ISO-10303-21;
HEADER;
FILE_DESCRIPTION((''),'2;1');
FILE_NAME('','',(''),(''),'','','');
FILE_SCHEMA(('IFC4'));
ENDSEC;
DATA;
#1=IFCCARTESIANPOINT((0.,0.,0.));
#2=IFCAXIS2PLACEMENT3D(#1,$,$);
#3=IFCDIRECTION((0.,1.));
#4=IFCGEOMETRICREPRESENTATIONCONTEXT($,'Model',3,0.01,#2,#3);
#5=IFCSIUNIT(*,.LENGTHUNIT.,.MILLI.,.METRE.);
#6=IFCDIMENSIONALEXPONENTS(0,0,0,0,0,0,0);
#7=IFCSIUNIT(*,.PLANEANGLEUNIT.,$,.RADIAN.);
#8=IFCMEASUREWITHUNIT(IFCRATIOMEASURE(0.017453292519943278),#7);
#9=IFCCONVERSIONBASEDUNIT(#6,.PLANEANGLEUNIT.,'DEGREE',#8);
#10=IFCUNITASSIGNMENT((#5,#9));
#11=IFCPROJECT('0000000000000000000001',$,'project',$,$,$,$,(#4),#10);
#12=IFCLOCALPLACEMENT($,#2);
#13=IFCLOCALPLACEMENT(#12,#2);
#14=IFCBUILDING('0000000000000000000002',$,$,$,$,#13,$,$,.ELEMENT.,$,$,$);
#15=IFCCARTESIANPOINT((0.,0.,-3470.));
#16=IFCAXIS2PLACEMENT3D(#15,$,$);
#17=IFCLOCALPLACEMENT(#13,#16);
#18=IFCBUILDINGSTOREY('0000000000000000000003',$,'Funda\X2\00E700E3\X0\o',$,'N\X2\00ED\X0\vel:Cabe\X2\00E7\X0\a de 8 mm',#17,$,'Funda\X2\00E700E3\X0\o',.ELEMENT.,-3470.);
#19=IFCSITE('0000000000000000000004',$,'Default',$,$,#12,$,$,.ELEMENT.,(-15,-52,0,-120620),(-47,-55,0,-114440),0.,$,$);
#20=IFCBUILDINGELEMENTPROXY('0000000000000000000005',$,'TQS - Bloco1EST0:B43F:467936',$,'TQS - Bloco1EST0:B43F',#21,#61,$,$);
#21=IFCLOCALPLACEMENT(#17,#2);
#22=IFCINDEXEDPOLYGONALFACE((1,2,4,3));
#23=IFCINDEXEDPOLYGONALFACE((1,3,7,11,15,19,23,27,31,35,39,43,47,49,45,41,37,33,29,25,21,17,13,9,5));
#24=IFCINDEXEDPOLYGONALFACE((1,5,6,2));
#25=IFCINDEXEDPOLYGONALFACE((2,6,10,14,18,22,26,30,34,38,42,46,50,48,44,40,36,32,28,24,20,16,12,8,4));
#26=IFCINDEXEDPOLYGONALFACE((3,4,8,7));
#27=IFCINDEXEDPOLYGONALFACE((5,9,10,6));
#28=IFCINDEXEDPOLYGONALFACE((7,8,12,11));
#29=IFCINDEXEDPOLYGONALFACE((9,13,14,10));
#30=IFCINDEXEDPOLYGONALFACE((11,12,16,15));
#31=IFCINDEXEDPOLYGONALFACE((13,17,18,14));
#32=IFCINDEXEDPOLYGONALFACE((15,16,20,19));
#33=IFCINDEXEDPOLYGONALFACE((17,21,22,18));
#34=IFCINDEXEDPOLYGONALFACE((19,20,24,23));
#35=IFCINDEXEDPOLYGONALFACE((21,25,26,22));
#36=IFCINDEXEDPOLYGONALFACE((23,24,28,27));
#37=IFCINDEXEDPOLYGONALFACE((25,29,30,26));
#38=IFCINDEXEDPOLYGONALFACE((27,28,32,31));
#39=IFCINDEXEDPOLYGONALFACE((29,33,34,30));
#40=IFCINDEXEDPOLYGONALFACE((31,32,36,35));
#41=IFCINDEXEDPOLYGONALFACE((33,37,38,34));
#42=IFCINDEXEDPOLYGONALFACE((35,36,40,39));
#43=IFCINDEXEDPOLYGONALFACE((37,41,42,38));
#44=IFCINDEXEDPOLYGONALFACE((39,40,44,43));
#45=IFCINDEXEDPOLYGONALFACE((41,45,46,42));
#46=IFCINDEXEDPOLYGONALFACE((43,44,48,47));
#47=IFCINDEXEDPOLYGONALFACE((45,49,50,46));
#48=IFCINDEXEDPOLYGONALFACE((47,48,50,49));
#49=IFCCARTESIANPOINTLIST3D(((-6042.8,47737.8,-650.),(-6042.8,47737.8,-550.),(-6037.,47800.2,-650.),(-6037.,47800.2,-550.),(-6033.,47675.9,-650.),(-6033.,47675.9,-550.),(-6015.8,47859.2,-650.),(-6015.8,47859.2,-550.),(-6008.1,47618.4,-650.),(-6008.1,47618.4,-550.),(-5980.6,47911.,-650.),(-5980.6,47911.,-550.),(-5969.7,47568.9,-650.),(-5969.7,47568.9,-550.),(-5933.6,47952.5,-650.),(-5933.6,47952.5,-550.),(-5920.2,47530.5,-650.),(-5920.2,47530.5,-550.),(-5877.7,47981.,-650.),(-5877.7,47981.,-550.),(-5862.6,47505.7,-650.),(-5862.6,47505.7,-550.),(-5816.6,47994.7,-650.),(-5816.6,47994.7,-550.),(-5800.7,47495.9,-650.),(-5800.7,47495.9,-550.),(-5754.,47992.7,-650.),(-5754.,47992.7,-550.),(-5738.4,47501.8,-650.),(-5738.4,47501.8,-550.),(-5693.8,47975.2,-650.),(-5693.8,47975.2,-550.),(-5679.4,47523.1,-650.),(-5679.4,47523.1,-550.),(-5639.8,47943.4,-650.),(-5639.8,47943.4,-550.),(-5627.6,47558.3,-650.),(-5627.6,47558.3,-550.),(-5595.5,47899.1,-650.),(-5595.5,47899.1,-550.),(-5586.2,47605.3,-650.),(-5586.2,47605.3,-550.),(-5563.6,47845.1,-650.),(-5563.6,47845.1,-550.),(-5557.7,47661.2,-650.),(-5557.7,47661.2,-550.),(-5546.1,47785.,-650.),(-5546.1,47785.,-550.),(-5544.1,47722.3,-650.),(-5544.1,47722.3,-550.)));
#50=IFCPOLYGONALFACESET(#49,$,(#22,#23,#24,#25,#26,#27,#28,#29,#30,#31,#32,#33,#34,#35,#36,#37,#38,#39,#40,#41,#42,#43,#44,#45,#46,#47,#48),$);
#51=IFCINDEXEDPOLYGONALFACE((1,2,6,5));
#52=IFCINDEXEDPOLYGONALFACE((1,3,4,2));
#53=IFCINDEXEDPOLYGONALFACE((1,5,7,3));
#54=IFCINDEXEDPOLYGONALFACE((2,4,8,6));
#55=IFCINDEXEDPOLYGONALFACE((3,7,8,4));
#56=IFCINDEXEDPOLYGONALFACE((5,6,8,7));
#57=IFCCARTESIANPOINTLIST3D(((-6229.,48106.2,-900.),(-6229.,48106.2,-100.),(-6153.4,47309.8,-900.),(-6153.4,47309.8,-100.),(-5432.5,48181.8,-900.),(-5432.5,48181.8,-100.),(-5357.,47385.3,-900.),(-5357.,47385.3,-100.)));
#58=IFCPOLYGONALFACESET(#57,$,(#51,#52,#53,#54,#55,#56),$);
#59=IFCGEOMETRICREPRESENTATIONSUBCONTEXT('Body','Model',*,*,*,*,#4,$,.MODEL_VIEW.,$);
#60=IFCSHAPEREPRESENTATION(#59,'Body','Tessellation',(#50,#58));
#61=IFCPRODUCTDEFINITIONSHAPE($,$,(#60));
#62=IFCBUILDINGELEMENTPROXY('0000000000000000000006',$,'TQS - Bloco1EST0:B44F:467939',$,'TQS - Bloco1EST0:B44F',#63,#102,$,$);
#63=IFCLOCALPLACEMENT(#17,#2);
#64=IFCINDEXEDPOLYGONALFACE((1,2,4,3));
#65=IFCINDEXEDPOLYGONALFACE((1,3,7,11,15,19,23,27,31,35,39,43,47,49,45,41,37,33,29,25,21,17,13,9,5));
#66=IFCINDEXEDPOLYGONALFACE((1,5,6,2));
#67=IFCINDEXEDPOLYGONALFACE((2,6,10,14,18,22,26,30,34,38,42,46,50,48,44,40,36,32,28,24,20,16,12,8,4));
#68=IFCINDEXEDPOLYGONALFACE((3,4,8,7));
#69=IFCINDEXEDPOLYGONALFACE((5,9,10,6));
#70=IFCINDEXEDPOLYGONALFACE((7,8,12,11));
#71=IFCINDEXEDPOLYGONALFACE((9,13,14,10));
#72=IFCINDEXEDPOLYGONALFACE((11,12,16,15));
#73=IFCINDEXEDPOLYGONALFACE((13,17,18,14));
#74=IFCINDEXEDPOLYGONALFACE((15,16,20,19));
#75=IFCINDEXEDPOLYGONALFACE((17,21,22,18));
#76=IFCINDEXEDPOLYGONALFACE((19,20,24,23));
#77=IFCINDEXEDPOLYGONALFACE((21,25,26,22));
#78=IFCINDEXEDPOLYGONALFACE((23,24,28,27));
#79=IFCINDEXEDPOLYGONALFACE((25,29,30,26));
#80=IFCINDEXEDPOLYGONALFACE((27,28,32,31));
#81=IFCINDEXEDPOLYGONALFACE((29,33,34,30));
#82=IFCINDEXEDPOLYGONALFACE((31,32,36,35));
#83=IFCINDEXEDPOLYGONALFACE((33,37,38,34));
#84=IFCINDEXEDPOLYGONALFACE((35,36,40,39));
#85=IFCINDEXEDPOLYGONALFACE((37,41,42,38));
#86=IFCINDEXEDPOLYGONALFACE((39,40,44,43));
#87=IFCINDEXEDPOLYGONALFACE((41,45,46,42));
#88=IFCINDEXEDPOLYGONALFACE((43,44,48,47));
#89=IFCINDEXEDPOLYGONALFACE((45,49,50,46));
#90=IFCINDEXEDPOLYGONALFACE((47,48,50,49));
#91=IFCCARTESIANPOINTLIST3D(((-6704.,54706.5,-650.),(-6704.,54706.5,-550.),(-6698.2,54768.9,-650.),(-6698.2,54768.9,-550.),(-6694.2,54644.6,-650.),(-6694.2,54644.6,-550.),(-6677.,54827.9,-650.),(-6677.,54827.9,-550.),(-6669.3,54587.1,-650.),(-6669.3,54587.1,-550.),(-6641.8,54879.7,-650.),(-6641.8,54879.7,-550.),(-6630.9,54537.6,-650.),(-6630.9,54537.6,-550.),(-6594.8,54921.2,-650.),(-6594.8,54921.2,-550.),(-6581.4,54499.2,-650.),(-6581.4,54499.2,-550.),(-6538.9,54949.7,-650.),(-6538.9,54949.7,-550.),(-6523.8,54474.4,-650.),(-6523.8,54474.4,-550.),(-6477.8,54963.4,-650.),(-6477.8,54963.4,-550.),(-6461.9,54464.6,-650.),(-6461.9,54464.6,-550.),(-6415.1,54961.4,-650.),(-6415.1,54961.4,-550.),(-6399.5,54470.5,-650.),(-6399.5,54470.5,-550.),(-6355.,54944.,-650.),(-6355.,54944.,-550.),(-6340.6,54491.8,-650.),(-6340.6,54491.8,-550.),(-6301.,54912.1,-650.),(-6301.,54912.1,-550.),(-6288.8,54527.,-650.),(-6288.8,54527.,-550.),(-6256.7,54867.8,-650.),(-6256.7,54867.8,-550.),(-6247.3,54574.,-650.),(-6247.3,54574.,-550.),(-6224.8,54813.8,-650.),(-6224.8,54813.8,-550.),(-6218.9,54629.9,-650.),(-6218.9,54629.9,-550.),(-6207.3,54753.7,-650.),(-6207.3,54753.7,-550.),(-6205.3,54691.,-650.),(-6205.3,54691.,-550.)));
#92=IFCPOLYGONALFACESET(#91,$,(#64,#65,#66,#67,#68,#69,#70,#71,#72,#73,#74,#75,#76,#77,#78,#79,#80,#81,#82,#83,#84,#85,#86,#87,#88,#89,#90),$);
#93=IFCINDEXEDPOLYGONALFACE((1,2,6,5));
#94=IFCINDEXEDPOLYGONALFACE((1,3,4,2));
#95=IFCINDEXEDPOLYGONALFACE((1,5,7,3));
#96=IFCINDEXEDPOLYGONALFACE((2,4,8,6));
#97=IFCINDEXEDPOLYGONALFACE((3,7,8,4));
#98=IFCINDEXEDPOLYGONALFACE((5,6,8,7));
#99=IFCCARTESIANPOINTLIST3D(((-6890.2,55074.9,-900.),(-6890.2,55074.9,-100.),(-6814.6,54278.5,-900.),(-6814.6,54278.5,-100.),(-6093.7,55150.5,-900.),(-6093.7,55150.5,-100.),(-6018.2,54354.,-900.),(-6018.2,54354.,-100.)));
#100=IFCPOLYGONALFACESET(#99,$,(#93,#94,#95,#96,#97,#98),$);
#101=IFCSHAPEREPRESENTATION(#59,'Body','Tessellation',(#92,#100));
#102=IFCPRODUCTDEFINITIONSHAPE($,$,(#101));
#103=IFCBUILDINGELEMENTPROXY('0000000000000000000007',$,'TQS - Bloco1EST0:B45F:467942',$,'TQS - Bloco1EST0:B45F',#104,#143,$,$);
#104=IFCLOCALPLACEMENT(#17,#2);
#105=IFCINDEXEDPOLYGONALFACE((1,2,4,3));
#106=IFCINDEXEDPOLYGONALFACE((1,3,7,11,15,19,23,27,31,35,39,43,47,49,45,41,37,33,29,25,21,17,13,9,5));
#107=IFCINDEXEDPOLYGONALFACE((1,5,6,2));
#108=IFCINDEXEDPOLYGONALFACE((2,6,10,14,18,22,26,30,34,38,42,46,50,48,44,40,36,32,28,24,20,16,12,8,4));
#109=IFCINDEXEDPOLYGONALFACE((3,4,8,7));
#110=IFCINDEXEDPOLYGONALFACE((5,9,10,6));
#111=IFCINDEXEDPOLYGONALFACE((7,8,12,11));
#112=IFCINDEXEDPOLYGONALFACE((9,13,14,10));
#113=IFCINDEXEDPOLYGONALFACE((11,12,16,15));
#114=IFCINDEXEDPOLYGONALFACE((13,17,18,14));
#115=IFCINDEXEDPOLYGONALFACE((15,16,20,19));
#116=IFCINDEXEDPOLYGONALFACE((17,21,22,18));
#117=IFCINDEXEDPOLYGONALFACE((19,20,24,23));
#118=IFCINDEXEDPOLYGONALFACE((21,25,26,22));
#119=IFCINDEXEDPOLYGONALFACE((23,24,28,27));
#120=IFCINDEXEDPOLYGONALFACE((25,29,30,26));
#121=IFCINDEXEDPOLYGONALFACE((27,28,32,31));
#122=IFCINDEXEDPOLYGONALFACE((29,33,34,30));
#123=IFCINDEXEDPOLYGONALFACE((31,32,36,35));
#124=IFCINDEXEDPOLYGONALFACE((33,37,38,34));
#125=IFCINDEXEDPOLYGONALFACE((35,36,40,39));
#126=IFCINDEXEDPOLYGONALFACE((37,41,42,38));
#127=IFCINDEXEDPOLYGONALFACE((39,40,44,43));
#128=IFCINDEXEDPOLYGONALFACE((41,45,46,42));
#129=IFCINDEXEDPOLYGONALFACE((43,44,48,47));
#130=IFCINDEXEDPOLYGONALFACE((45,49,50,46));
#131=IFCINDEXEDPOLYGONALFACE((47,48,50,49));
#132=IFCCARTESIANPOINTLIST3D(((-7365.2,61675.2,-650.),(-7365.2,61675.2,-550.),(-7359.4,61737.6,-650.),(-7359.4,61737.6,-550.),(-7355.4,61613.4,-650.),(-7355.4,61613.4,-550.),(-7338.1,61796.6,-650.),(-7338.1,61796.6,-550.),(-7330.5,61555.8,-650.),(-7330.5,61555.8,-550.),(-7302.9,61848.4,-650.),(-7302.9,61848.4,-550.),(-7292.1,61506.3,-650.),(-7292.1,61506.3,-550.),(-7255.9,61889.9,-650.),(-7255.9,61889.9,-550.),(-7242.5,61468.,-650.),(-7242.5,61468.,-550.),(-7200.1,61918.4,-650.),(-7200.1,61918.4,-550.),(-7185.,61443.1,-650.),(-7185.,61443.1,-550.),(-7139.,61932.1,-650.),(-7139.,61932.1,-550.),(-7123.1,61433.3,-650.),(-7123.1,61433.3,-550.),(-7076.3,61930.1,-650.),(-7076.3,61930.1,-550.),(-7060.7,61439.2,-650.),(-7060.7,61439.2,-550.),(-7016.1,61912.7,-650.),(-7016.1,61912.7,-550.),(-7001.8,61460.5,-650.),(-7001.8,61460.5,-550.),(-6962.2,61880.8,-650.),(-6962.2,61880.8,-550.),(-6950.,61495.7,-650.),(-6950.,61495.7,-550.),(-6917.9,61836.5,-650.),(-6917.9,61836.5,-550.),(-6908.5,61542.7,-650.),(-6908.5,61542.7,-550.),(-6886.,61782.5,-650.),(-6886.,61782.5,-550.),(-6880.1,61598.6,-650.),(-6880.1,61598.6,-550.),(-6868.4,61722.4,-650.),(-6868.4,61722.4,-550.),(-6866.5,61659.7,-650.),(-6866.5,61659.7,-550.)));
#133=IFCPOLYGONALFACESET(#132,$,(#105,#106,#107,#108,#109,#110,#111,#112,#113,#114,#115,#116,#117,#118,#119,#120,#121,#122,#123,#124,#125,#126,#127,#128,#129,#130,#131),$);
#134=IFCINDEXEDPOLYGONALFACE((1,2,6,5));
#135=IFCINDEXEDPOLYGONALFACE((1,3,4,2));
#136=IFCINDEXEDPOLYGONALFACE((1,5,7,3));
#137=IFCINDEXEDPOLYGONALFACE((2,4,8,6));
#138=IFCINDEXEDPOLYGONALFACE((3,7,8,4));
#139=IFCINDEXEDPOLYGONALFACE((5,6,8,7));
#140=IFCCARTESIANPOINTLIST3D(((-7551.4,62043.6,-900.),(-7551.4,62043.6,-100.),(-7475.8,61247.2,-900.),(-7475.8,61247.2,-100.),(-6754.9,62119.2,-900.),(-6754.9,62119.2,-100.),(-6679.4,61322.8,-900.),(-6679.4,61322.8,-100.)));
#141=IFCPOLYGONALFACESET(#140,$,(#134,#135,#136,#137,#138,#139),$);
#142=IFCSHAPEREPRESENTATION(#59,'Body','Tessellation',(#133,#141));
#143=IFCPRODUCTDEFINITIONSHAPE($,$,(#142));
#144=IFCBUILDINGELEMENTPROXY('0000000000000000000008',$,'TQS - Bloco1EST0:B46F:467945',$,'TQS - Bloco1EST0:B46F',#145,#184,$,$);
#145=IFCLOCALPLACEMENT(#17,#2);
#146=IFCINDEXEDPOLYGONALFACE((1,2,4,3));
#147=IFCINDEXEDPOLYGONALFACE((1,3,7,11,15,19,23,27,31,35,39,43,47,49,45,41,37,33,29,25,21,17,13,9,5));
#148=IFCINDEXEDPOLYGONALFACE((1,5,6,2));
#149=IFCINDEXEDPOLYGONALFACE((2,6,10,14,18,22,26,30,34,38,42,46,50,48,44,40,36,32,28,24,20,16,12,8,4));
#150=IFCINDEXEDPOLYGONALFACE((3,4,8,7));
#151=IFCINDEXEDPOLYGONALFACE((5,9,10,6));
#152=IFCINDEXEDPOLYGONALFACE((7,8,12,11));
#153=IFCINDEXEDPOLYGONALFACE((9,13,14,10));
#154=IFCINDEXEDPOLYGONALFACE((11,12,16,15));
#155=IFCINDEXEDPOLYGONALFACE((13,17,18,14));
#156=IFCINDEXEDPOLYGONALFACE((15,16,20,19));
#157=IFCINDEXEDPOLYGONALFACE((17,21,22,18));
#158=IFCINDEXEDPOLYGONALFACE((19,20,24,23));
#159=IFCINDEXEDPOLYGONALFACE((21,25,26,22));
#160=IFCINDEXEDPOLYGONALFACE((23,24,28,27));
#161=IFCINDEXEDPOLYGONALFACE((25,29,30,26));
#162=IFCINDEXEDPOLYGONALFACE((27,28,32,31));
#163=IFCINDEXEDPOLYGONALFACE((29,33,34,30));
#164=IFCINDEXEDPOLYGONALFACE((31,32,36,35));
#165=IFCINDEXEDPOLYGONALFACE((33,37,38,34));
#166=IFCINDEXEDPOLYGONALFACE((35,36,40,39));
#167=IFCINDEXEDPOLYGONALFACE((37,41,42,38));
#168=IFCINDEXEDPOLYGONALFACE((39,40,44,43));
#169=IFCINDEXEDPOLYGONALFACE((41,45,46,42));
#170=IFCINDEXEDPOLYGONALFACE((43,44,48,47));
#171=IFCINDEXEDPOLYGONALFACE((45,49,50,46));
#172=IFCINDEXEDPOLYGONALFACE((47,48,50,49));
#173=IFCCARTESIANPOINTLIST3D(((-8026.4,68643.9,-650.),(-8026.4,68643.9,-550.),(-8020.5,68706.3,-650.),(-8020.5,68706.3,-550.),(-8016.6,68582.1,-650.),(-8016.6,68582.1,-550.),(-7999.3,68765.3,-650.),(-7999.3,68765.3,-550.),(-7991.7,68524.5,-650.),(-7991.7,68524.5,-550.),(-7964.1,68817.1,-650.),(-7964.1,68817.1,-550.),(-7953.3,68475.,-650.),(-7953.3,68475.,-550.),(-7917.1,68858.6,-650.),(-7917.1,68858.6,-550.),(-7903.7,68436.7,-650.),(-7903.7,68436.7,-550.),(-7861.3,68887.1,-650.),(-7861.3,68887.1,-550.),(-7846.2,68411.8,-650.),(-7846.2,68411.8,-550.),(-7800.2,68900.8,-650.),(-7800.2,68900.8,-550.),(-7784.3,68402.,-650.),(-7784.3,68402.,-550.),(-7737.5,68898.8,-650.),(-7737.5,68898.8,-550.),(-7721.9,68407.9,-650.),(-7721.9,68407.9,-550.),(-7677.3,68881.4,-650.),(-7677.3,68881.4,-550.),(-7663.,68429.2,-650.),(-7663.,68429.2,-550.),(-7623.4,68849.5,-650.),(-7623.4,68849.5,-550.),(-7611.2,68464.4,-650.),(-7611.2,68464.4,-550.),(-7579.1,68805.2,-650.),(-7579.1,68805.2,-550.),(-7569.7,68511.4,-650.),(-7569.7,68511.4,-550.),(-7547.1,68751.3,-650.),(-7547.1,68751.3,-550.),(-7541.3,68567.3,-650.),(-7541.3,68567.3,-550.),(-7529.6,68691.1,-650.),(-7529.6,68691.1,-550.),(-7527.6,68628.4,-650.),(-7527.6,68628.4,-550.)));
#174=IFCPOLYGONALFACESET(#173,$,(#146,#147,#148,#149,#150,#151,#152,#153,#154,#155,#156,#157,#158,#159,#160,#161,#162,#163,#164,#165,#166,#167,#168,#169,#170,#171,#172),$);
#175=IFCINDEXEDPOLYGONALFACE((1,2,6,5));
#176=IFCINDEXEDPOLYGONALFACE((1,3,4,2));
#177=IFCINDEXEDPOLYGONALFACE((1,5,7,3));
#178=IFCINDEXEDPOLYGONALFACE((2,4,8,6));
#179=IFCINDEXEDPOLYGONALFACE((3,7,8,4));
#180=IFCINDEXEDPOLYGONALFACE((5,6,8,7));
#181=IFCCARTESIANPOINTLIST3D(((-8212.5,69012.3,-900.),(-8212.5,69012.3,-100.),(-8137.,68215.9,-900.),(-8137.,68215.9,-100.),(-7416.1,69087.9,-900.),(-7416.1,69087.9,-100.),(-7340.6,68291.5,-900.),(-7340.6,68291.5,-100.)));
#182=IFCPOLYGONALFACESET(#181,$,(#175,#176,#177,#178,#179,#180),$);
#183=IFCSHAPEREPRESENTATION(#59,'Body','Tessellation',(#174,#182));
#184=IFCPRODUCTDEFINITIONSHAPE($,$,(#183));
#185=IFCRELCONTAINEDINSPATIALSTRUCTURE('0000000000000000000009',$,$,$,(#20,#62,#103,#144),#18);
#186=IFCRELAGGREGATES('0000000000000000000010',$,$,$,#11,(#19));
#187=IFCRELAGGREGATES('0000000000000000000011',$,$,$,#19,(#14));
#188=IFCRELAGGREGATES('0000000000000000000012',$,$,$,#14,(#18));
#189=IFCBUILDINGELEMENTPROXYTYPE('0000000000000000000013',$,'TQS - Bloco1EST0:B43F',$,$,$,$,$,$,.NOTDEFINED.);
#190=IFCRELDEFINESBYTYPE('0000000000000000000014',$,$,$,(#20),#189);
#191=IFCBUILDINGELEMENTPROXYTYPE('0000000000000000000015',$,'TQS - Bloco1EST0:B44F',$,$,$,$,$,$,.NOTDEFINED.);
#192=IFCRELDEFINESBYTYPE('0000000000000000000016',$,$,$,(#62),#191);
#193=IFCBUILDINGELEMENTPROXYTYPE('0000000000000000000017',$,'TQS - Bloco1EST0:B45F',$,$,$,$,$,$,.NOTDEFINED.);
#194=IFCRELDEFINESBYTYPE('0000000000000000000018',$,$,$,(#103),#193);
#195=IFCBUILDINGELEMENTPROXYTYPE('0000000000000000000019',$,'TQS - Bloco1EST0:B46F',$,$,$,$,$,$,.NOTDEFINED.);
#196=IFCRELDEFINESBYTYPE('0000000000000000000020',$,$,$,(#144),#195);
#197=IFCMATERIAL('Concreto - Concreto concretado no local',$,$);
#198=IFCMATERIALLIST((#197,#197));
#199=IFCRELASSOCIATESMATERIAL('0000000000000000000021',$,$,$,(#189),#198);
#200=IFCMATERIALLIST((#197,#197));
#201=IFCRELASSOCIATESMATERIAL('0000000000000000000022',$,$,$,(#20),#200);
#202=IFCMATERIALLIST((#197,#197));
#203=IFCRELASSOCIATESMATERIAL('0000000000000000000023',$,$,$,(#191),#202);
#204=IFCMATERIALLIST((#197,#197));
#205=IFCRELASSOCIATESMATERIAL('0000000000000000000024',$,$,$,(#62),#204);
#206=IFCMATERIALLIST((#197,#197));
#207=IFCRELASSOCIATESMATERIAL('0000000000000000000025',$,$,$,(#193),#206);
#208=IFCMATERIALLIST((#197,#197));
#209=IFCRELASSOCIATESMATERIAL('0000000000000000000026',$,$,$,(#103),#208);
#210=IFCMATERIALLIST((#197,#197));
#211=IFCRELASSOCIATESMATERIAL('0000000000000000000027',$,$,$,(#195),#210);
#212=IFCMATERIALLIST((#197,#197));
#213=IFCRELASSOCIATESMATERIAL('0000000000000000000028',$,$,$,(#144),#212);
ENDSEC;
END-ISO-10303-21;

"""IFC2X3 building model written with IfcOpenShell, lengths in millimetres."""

from ifc_helpers import new_model, entity, si_unit, converted_unit, direction, frame, frame_2d, origin, origin_2d_with_axis, place, context, subcontext, project, spatial, rectangle, circle, extrude, source, transform, mapped, material, material_list, type_object, type_shapes, element, save


model = new_model("IFC2X3")

# Units and contexts
model_context = context("Model", 3, precision=0.01, world=origin(), true_north=direction((0.0, 1.0)))
body_context = subcontext(model_context, "Body", "Model", "MODEL_VIEW")
ifc_project = project(units=[si_unit("LENGTHUNIT", "METRE", prefix="MILLI"), converted_unit("PLANEANGLEUNIT", "DEGREE", entity("IfcRatioMeasure", 0.017453292519943278), si_unit("PLANEANGLEUNIT", "RADIAN"), dimensions=[0, 0, 0, 0, 0, 0, 0])], contexts=[model_context])

# Site, building, storey
site_placement = place(None, origin())
site = spatial("IfcSite", under=ifc_project, at=site_placement, Name="Default", CompositionType="ELEMENT", RefLatitude=(-15, -52, 0, -120620), RefLongitude=(-47, -55, 0, -114440), RefElevation=0.0)
building_placement = place(site_placement, origin())
building = spatial("IfcBuilding", under=site, at=building_placement, CompositionType="ELEMENT")
storey_placement = place(building_placement, frame((0.0, 0.0, -3470.0)))
storey = spatial("IfcBuildingStorey", under=building, at=storey_placement, Name="Fundação", ObjectType="Nível:Cabeça de 8 mm", LongName="Fundação", CompositionType="ELEMENT", Elevation=-3470.0)

# Building element proxies
ifc_material_1 = material(Name="Concreto - Concreto concretado no local")
ifc_material_list_1 = material_list([ifc_material_1, ifc_material_1])
ifc_material_list_2 = material_list([ifc_material_1, ifc_material_1])
building_element_proxy_type_1 = type_object("IfcBuildingElementProxyType", Name="TQS - Bloco1EST0:B43F", PredefinedType="NOTDEFINED", material=ifc_material_list_2)
shared_shape_1 = source(origin(), body_context, "Body", "SweptSolid", [
    extrude(circle(Radius=250.0, at=frame_2d((0.0, 0.0), x_axis=(1.0, 0.0))), frame((0.0, 0.0, -550.0)), (0.0, 0.0, 1.0), 100.0),
    extrude(rectangle(XDim=800.0, YDim=800.0, at=origin_2d_with_axis()), frame((0.0, 0.0, -800.0), z_axis=(0.0, 0.0, 1.0), x_axis=(-1.0, 0.0, 0.0)), (0.0, 0.0, 1.0), 800.0),
])
type_shapes(building_element_proxy_type_1, [shared_shape_1])
proxy_1_placement = place(storey_placement, frame((-5793.0, 47745.8, -100.0), z_axis=(0.0, 0.0, 1.0), x_axis=(-0.094456, 0.995529, 0.0)))
element("IfcBuildingElementProxy", 1, at=proxy_1_placement, inside=storey, type_object=building_element_proxy_type_1, material=ifc_material_list_1, Name="TQS - Bloco1EST0:B43F:467936", ObjectType="TQS - Bloco1EST0:B43F", context=body_context, shape_type="MappedRepresentation", body=[
    mapped(shared_shape_1, transform((0.0, 0.0, 0.0), scale=1.0)),
])
ifc_material_list_3 = material_list([ifc_material_1, ifc_material_1])
ifc_material_list_4 = material_list([ifc_material_1, ifc_material_1])
building_element_proxy_type_2 = type_object("IfcBuildingElementProxyType", Name="TQS - Bloco1EST0:B44F", PredefinedType="NOTDEFINED", material=ifc_material_list_4)
shared_shape_2 = source(origin(), body_context, "Body", "SweptSolid", [
    extrude(circle(Radius=250.0, at=frame_2d((0.0, 0.0), x_axis=(1.0, 0.0))), frame((0.0, 0.0, -550.0)), (0.0, 0.0, 1.0), 100.0),
    extrude(rectangle(XDim=800.0, YDim=800.0, at=origin_2d_with_axis()), frame((0.0, 0.0, -800.0), z_axis=(0.0, 0.0, 1.0), x_axis=(-1.0, 0.0, 0.0)), (0.0, 0.0, 1.0), 800.0),
])
type_shapes(building_element_proxy_type_2, [shared_shape_2])
proxy_2_placement = place(storey_placement, frame((-6454.2, 54714.5, -100.0), z_axis=(0.0, 0.0, 1.0), x_axis=(-0.094456, 0.995529, 0.0)))
element("IfcBuildingElementProxy", 2, at=proxy_2_placement, inside=storey, type_object=building_element_proxy_type_2, material=ifc_material_list_3, Name="TQS - Bloco1EST0:B44F:467939", ObjectType="TQS - Bloco1EST0:B44F", context=body_context, shape_type="MappedRepresentation", body=[
    mapped(shared_shape_2, transform((0.0, 0.0, 0.0), scale=1.0)),
])
ifc_material_list_5 = material_list([ifc_material_1, ifc_material_1])
ifc_material_list_6 = material_list([ifc_material_1, ifc_material_1])
building_element_proxy_type_3 = type_object("IfcBuildingElementProxyType", Name="TQS - Bloco1EST0:B45F", PredefinedType="NOTDEFINED", material=ifc_material_list_6)
shared_shape_3 = source(origin(), body_context, "Body", "SweptSolid", [
    extrude(circle(Radius=250.0, at=frame_2d((0.0, 0.0), x_axis=(1.0, 0.0))), frame((0.0, 0.0, -550.0)), (0.0, 0.0, 1.0), 100.0),
    extrude(rectangle(XDim=800.0, YDim=800.0, at=origin_2d_with_axis()), frame((0.0, 0.0, -800.0), z_axis=(0.0, 0.0, 1.0), x_axis=(-1.0, 0.0, 0.0)), (0.0, 0.0, 1.0), 800.0),
])
type_shapes(building_element_proxy_type_3, [shared_shape_3])
proxy_3_placement = place(storey_placement, frame((-7115.4, 61683.2, -100.0), z_axis=(0.0, 0.0, 1.0), x_axis=(-0.094456, 0.995529, 0.0)))
element("IfcBuildingElementProxy", 3, at=proxy_3_placement, inside=storey, type_object=building_element_proxy_type_3, material=ifc_material_list_5, Name="TQS - Bloco1EST0:B45F:467942", ObjectType="TQS - Bloco1EST0:B45F", context=body_context, shape_type="MappedRepresentation", body=[
    mapped(shared_shape_3, transform((0.0, 0.0, 0.0), scale=1.0)),
])
ifc_material_list_7 = material_list([ifc_material_1, ifc_material_1])
ifc_material_list_8 = material_list([ifc_material_1, ifc_material_1])
building_element_proxy_type_4 = type_object("IfcBuildingElementProxyType", Name="TQS - Bloco1EST0:B46F", PredefinedType="NOTDEFINED", material=ifc_material_list_8)
shared_shape_4 = source(origin(), body_context, "Body", "SweptSolid", [
    extrude(circle(Radius=250.0, at=frame_2d((0.0, 0.0), x_axis=(1.0, 0.0))), frame((0.0, 0.0, -550.0)), (0.0, 0.0, 1.0), 100.0),
    extrude(rectangle(XDim=800.0, YDim=800.0, at=origin_2d_with_axis()), frame((0.0, 0.0, -800.0), z_axis=(0.0, 0.0, 1.0), x_axis=(-1.0, 0.0, 0.0)), (0.0, 0.0, 1.0), 800.0),
])
type_shapes(building_element_proxy_type_4, [shared_shape_4])
proxy_4_placement = place(storey_placement, frame((-7776.5, 68651.9, -100.0), z_axis=(0.0, 0.0, 1.0), x_axis=(-0.094456, 0.995529, 0.0)))
element("IfcBuildingElementProxy", 4, at=proxy_4_placement, inside=storey, type_object=building_element_proxy_type_4, material=ifc_material_list_7, Name="TQS - Bloco1EST0:B46F:467945", ObjectType="TQS - Bloco1EST0:B46F", context=body_context, shape_type="MappedRepresentation", body=[
    mapped(shared_shape_4, transform((0.0, 0.0, 0.0), scale=1.0)),
])

save(model, "model.ifc")
